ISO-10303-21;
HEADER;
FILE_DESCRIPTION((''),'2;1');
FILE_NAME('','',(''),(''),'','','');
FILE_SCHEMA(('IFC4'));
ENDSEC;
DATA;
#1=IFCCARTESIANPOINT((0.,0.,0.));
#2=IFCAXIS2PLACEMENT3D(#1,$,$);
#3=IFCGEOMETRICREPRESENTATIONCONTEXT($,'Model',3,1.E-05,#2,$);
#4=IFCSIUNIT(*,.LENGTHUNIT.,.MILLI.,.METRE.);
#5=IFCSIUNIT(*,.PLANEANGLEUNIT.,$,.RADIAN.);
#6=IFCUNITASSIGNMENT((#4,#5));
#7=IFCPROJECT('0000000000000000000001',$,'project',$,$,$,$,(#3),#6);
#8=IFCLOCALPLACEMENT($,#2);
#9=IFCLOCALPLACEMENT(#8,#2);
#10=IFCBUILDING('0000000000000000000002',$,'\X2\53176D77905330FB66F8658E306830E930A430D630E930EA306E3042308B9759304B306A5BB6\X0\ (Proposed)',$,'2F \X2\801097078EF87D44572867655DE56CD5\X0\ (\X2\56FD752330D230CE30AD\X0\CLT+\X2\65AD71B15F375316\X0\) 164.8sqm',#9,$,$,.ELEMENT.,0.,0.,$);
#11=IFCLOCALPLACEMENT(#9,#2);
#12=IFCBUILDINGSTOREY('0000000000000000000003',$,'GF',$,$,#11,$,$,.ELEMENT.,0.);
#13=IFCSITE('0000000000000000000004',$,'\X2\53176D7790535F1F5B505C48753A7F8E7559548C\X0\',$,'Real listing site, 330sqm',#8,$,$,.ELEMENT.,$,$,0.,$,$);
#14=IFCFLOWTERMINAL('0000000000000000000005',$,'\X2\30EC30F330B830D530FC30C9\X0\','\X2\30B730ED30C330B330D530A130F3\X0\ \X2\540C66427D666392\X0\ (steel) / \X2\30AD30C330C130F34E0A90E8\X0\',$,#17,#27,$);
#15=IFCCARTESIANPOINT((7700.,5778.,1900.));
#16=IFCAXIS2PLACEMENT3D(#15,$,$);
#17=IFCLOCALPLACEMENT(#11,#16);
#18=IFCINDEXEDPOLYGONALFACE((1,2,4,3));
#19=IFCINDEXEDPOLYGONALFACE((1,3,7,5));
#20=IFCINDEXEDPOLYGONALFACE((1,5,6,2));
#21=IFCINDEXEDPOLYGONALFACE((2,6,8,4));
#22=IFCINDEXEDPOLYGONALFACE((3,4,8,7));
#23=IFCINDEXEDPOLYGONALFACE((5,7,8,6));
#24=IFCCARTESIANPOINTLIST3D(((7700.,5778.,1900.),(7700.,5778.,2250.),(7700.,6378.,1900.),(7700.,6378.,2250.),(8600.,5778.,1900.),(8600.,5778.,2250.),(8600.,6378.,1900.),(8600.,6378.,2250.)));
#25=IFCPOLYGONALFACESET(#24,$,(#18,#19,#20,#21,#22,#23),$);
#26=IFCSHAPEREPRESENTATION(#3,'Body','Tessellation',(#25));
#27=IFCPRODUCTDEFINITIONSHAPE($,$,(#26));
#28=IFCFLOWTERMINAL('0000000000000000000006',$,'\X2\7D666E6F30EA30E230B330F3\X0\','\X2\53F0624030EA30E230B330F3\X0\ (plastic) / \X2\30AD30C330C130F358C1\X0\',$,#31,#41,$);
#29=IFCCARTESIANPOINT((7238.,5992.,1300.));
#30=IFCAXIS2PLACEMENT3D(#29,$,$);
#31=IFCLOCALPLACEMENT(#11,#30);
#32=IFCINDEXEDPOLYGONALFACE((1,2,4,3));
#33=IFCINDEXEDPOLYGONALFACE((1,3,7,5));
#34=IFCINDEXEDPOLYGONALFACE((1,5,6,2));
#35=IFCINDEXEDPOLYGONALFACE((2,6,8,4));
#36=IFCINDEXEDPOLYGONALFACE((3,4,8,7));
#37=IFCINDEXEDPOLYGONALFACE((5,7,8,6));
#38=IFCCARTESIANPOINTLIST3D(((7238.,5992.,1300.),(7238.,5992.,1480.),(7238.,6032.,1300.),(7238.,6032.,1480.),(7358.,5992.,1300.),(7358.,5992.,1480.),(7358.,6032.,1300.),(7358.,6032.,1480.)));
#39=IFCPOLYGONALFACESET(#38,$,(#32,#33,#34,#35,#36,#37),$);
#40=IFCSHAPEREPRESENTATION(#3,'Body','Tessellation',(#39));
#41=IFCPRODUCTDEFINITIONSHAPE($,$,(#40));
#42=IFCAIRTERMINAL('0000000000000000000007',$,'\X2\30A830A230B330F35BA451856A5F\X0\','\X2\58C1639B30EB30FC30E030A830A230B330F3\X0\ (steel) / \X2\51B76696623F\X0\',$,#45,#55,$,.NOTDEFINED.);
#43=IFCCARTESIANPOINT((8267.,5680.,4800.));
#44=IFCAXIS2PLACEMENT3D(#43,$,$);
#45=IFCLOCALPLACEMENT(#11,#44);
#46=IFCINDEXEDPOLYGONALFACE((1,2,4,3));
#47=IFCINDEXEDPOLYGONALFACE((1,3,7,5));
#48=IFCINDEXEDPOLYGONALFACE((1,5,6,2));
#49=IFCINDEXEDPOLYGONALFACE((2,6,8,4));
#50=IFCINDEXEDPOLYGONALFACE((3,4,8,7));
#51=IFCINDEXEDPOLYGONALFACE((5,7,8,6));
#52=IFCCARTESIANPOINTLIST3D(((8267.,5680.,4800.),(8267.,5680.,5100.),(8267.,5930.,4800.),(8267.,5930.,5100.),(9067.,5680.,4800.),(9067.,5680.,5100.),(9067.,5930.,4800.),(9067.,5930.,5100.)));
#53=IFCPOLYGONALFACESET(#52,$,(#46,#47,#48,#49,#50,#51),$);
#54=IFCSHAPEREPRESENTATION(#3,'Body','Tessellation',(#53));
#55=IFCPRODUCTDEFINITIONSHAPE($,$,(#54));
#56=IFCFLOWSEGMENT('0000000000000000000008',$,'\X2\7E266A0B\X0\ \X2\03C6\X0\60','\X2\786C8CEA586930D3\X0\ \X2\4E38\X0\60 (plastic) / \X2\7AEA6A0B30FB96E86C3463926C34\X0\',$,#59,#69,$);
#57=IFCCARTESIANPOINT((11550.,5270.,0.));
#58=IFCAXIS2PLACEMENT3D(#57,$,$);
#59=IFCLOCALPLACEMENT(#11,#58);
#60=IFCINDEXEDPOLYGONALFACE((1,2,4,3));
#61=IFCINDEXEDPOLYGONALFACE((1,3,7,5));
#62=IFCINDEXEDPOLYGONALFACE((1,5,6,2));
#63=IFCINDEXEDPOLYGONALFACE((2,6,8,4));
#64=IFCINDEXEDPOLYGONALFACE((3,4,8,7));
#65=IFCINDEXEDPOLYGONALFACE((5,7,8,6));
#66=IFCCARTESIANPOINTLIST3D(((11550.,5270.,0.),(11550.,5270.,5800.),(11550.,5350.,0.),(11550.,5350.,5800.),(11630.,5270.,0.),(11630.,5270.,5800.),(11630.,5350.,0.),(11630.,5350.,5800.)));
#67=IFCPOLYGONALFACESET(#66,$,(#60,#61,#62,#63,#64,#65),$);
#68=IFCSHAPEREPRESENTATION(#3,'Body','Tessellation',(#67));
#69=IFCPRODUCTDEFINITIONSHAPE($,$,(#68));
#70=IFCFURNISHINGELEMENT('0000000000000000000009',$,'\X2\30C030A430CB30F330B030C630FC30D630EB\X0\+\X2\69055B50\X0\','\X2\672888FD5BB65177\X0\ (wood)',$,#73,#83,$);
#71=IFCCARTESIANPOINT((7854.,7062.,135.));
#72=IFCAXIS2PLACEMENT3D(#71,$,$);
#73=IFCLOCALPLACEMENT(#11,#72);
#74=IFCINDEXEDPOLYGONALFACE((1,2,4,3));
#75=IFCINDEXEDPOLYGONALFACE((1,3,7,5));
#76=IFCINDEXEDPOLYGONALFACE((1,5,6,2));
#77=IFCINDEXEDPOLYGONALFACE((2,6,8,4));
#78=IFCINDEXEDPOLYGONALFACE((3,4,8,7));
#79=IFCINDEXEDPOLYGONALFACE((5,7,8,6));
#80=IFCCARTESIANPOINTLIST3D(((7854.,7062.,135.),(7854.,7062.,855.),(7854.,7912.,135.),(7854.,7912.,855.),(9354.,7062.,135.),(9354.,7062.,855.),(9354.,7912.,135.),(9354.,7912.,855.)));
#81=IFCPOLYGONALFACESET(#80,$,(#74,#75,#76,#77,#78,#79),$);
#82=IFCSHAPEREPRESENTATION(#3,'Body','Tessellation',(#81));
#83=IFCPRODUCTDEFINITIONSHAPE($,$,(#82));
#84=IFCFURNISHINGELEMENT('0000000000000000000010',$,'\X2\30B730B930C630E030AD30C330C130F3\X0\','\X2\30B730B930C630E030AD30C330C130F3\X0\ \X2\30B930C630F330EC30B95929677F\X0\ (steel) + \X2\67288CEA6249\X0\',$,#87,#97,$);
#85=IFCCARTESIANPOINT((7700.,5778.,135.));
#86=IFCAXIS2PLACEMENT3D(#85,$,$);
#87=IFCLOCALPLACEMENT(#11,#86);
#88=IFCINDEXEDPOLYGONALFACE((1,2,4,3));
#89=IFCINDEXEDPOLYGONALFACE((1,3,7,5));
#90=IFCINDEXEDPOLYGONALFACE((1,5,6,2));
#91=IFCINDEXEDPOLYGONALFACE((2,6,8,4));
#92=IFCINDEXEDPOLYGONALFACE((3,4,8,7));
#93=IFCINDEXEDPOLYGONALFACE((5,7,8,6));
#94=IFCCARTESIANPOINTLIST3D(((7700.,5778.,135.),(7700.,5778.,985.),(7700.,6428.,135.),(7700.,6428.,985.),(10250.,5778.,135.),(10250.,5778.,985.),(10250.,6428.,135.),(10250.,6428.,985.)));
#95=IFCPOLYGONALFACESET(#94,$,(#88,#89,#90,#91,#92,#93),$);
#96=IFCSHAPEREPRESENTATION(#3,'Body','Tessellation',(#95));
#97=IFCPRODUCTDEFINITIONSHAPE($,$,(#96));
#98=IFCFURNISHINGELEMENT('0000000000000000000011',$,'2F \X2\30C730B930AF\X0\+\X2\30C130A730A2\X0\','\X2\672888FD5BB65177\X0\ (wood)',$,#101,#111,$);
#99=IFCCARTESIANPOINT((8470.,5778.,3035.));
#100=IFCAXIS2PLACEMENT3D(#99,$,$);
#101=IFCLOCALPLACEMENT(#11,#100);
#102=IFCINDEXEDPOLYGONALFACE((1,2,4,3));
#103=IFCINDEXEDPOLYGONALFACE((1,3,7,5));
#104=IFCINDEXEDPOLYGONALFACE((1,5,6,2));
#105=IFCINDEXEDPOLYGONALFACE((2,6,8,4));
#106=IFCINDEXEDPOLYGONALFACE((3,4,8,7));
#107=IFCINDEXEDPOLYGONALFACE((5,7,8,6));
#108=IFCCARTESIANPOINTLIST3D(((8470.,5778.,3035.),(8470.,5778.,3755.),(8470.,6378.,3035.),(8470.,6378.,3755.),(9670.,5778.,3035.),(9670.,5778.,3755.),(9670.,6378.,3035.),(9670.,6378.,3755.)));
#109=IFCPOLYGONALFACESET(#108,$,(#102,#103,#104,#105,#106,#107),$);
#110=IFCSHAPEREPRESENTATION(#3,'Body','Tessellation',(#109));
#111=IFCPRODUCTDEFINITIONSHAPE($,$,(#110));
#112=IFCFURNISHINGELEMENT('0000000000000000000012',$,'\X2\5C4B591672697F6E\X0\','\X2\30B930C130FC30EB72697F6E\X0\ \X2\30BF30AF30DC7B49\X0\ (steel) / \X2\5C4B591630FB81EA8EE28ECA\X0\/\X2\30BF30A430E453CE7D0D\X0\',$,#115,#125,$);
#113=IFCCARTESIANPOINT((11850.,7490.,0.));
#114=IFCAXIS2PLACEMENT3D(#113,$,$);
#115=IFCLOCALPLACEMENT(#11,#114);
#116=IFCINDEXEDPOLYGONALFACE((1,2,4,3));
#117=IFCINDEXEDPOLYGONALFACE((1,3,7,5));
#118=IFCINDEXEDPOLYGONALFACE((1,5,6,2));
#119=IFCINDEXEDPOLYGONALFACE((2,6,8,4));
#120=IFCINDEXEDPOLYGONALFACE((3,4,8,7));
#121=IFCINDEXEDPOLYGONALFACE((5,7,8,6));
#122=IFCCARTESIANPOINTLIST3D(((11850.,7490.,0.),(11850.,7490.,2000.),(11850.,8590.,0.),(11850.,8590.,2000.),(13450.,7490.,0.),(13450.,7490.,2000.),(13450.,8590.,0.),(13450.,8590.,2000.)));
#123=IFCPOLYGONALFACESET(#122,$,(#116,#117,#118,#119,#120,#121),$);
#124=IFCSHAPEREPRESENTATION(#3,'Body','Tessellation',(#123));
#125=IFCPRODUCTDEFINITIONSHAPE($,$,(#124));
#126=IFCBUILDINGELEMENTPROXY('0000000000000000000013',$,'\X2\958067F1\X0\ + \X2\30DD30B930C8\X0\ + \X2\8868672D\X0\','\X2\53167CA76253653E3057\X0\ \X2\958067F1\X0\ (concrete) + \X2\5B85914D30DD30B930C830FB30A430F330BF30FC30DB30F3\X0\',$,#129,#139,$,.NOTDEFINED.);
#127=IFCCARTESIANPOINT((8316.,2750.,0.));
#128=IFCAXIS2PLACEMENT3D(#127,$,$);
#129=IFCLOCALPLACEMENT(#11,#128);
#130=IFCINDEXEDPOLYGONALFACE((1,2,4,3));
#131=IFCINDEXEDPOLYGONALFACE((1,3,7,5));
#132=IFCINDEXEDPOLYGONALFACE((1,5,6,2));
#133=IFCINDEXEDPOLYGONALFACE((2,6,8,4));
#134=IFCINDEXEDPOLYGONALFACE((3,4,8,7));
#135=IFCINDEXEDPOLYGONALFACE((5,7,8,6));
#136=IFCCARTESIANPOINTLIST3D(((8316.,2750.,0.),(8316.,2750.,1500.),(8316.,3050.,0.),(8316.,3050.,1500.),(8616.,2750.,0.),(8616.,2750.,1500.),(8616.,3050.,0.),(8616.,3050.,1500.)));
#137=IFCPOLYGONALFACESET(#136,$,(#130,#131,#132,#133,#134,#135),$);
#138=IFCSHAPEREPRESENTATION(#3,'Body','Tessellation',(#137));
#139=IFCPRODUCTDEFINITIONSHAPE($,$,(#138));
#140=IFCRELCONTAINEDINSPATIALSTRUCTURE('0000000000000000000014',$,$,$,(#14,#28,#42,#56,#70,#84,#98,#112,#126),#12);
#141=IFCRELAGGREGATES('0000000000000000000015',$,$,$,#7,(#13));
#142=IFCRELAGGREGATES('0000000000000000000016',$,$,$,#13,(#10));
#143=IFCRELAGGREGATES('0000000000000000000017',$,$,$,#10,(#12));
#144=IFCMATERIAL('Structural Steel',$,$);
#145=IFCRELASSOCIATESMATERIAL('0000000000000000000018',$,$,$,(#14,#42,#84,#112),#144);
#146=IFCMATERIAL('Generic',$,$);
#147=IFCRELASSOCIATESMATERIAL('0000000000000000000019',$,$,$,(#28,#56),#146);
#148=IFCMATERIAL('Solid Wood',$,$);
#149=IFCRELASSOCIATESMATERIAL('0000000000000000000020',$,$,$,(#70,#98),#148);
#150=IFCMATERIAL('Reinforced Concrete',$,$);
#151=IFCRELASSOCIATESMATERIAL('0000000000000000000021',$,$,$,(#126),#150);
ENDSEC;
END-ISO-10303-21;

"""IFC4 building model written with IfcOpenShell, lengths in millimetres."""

from ifc_helpers import new_model, si_unit, frame, frame_2d, origin, place, context, project, spatial, rectangle, extrude, material, element, save


model = new_model("IFC4")

# Units and contexts
model_context = context("Model", 3, precision=1e-05, world=origin())
ifc_project = project(units=[si_unit("LENGTHUNIT", "METRE", prefix="MILLI"), si_unit("PLANEANGLEUNIT", "RADIAN")], contexts=[model_context])

# Site, building, storey
site_placement = place(None, origin())
site = spatial("IfcSite", under=ifc_project, at=site_placement, Name="北海道弟子屈町美留和", ObjectType="Real listing site, 330sqm", CompositionType="ELEMENT", RefElevation=0.0)
building_placement = place(site_placement, origin())
building = spatial("IfcBuilding", under=site, at=building_placement, Name="北海道・書斎とライブラリのある静かな家 (Proposed)", ObjectType="2F 耐震軸組在来工法 (国産ヒノキCLT+断熱強化) 164.8sqm", CompositionType="ELEMENT", ElevationOfRefHeight=0.0, ElevationOfTerrain=0.0)
storey_placement = place(building_placement, origin())
storey = spatial("IfcBuildingStorey", under=building, at=storey_placement, Name="GF", CompositionType="ELEMENT", Elevation=0.0)

# Shared definitions
ifc_material_1 = material(Name="Solid Wood")

# Shared definitions
ifc_material_2 = material(Name="Reinforced Concrete")

# Shared definitions
ifc_material_3 = material(Name="Structural Steel")

# Flow terminals
flow_terminal_1_placement = place(storey_placement, frame((7700.0, 5778.0, 1900.0)))
element("IfcFlowTerminal", 1, at=flow_terminal_1_placement, inside=storey, material=ifc_material_3, Name="レンジフード", Description="シロッコファン 同時給排 (steel) / キッチン上部", context=model_context, shape_type="SweptSolid", body=[
    extrude(rectangle(XDim=900.0, YDim=600.0, at=frame_2d((450.0, 300.0))), frame((7700.0, 5778.0, 1900.0)), (0.0, 0.0, 1.0), 350.0),
])
ifc_material_4 = material(Name="Generic")
flow_terminal_2_placement = place(storey_placement, frame((7238.0, 5992.0, 1300.0)))
element("IfcFlowTerminal", 2, at=flow_terminal_2_placement, inside=storey, material=ifc_material_4, Name="給湯リモコン", Description="台所リモコン (plastic) / キッチン壁", context=model_context, shape_type="SweptSolid", body=[
    extrude(rectangle(XDim=120.0, YDim=40.0, at=frame_2d((60.0, 20.0))), frame((7238.0, 5992.0, 1300.0)), (0.0, 0.0, 1.0), 180.0),
])

# Air terminal
air_terminal_placement = place(storey_placement, frame((8267.0, 5680.0, 4800.0)))
element("IfcAirTerminal", 3, at=air_terminal_placement, inside=storey, material=ifc_material_3, Name="エアコン室内機", Description="壁掛ルームエアコン (steel) / 冷暖房", PredefinedType="NOTDEFINED", context=model_context, shape_type="SweptSolid", body=[
    extrude(rectangle(XDim=800.0, YDim=250.0, at=frame_2d((400.0, 125.0))), frame((8267.0, 5680.0, 4800.0)), (0.0, 0.0, 1.0), 300.0),
])

# Flow segment
flow_segment_placement = place(storey_placement, frame((11550.0, 5270.0, 0.0)))
element("IfcFlowSegment", 4, at=flow_segment_placement, inside=storey, material=ifc_material_4, Name="縦樋 φ60", Description="硬質塩ビ 丸60 (plastic) / 竪樋・雨水排水", context=model_context, shape_type="SweptSolid", body=[
    extrude(rectangle(XDim=80.0, YDim=80.0, at=frame_2d((40.0, 40.0))), frame((11550.0, 5270.0, 0.0)), (0.0, 0.0, 1.0), 5800.0),
])

# Furnishing elements
furnishing_1_placement = place(storey_placement, frame((7854.0, 7062.0, 135.0)))
element("IfcFurnishingElement", 5, at=furnishing_1_placement, inside=storey, material=ifc_material_1, Name="ダイニングテーブル+椅子", Description="木製家具 (wood)", context=model_context, shape_type="SweptSolid", body=[
    extrude(rectangle(XDim=1500.0, YDim=850.0, at=frame_2d((750.0, 425.0))), frame((7854.0, 7062.0, 135.0)), (0.0, 0.0, 1.0), 720.0),
])
furnishing_2_placement = place(storey_placement, frame((7700.0, 5778.0, 135.0)))
element("IfcFurnishingElement", 6, at=furnishing_2_placement, inside=storey, material=ifc_material_3, Name="システムキッチン", Description="システムキッチン ステンレス天板 (steel) + 木質扉", context=model_context, shape_type="SweptSolid", body=[
    extrude(rectangle(XDim=2550.0, YDim=650.0, at=frame_2d((1275.0, 325.0))), frame((7700.0, 5778.0, 135.0)), (0.0, 0.0, 1.0), 850.0),
])
furnishing_3_placement = place(storey_placement, frame((8470.0, 5778.0, 3035.0)))
element("IfcFurnishingElement", 7, at=furnishing_3_placement, inside=storey, material=ifc_material_1, Name="2F デスク+チェア", Description="木製家具 (wood)", context=model_context, shape_type="SweptSolid", body=[
    extrude(rectangle(XDim=1200.0, YDim=600.0, at=frame_2d((600.0, 300.0))), frame((8470.0, 5778.0, 3035.0)), (0.0, 0.0, 1.0), 720.0),
])
furnishing_4_placement = place(storey_placement, frame((11850.0, 7490.0, 0.0)))
element("IfcFurnishingElement", 8, at=furnishing_4_placement, inside=storey, material=ifc_material_3, Name="屋外物置", Description="スチール物置 タクボ等 (steel) / 屋外・自転車/タイヤ収納", context=model_context, shape_type="SweptSolid", body=[
    extrude(rectangle(XDim=1600.0, YDim=1100.0, at=frame_2d((800.0, 550.0))), frame((11850.0, 7490.0, 0.0)), (0.0, 0.0, 1.0), 2000.0),
])

# Building element proxy
proxy_placement = place(storey_placement, frame((8316.0, 2750.0, 0.0)))
element("IfcBuildingElementProxy", 9, at=proxy_placement, inside=storey, material=ifc_material_2, Name="門柱 + ポスト + 表札", Description="化粧打放し 門柱 (concrete) + 宅配ポスト・インターホン", PredefinedType="NOTDEFINED", context=model_context, shape_type="SweptSolid", body=[
    extrude(rectangle(XDim=300.0, YDim=300.0, at=frame_2d((150.0, 150.0))), frame((8316.0, 2750.0, 0.0)), (0.0, 0.0, 1.0), 1500.0),
])

save(model, "model.ifc")
